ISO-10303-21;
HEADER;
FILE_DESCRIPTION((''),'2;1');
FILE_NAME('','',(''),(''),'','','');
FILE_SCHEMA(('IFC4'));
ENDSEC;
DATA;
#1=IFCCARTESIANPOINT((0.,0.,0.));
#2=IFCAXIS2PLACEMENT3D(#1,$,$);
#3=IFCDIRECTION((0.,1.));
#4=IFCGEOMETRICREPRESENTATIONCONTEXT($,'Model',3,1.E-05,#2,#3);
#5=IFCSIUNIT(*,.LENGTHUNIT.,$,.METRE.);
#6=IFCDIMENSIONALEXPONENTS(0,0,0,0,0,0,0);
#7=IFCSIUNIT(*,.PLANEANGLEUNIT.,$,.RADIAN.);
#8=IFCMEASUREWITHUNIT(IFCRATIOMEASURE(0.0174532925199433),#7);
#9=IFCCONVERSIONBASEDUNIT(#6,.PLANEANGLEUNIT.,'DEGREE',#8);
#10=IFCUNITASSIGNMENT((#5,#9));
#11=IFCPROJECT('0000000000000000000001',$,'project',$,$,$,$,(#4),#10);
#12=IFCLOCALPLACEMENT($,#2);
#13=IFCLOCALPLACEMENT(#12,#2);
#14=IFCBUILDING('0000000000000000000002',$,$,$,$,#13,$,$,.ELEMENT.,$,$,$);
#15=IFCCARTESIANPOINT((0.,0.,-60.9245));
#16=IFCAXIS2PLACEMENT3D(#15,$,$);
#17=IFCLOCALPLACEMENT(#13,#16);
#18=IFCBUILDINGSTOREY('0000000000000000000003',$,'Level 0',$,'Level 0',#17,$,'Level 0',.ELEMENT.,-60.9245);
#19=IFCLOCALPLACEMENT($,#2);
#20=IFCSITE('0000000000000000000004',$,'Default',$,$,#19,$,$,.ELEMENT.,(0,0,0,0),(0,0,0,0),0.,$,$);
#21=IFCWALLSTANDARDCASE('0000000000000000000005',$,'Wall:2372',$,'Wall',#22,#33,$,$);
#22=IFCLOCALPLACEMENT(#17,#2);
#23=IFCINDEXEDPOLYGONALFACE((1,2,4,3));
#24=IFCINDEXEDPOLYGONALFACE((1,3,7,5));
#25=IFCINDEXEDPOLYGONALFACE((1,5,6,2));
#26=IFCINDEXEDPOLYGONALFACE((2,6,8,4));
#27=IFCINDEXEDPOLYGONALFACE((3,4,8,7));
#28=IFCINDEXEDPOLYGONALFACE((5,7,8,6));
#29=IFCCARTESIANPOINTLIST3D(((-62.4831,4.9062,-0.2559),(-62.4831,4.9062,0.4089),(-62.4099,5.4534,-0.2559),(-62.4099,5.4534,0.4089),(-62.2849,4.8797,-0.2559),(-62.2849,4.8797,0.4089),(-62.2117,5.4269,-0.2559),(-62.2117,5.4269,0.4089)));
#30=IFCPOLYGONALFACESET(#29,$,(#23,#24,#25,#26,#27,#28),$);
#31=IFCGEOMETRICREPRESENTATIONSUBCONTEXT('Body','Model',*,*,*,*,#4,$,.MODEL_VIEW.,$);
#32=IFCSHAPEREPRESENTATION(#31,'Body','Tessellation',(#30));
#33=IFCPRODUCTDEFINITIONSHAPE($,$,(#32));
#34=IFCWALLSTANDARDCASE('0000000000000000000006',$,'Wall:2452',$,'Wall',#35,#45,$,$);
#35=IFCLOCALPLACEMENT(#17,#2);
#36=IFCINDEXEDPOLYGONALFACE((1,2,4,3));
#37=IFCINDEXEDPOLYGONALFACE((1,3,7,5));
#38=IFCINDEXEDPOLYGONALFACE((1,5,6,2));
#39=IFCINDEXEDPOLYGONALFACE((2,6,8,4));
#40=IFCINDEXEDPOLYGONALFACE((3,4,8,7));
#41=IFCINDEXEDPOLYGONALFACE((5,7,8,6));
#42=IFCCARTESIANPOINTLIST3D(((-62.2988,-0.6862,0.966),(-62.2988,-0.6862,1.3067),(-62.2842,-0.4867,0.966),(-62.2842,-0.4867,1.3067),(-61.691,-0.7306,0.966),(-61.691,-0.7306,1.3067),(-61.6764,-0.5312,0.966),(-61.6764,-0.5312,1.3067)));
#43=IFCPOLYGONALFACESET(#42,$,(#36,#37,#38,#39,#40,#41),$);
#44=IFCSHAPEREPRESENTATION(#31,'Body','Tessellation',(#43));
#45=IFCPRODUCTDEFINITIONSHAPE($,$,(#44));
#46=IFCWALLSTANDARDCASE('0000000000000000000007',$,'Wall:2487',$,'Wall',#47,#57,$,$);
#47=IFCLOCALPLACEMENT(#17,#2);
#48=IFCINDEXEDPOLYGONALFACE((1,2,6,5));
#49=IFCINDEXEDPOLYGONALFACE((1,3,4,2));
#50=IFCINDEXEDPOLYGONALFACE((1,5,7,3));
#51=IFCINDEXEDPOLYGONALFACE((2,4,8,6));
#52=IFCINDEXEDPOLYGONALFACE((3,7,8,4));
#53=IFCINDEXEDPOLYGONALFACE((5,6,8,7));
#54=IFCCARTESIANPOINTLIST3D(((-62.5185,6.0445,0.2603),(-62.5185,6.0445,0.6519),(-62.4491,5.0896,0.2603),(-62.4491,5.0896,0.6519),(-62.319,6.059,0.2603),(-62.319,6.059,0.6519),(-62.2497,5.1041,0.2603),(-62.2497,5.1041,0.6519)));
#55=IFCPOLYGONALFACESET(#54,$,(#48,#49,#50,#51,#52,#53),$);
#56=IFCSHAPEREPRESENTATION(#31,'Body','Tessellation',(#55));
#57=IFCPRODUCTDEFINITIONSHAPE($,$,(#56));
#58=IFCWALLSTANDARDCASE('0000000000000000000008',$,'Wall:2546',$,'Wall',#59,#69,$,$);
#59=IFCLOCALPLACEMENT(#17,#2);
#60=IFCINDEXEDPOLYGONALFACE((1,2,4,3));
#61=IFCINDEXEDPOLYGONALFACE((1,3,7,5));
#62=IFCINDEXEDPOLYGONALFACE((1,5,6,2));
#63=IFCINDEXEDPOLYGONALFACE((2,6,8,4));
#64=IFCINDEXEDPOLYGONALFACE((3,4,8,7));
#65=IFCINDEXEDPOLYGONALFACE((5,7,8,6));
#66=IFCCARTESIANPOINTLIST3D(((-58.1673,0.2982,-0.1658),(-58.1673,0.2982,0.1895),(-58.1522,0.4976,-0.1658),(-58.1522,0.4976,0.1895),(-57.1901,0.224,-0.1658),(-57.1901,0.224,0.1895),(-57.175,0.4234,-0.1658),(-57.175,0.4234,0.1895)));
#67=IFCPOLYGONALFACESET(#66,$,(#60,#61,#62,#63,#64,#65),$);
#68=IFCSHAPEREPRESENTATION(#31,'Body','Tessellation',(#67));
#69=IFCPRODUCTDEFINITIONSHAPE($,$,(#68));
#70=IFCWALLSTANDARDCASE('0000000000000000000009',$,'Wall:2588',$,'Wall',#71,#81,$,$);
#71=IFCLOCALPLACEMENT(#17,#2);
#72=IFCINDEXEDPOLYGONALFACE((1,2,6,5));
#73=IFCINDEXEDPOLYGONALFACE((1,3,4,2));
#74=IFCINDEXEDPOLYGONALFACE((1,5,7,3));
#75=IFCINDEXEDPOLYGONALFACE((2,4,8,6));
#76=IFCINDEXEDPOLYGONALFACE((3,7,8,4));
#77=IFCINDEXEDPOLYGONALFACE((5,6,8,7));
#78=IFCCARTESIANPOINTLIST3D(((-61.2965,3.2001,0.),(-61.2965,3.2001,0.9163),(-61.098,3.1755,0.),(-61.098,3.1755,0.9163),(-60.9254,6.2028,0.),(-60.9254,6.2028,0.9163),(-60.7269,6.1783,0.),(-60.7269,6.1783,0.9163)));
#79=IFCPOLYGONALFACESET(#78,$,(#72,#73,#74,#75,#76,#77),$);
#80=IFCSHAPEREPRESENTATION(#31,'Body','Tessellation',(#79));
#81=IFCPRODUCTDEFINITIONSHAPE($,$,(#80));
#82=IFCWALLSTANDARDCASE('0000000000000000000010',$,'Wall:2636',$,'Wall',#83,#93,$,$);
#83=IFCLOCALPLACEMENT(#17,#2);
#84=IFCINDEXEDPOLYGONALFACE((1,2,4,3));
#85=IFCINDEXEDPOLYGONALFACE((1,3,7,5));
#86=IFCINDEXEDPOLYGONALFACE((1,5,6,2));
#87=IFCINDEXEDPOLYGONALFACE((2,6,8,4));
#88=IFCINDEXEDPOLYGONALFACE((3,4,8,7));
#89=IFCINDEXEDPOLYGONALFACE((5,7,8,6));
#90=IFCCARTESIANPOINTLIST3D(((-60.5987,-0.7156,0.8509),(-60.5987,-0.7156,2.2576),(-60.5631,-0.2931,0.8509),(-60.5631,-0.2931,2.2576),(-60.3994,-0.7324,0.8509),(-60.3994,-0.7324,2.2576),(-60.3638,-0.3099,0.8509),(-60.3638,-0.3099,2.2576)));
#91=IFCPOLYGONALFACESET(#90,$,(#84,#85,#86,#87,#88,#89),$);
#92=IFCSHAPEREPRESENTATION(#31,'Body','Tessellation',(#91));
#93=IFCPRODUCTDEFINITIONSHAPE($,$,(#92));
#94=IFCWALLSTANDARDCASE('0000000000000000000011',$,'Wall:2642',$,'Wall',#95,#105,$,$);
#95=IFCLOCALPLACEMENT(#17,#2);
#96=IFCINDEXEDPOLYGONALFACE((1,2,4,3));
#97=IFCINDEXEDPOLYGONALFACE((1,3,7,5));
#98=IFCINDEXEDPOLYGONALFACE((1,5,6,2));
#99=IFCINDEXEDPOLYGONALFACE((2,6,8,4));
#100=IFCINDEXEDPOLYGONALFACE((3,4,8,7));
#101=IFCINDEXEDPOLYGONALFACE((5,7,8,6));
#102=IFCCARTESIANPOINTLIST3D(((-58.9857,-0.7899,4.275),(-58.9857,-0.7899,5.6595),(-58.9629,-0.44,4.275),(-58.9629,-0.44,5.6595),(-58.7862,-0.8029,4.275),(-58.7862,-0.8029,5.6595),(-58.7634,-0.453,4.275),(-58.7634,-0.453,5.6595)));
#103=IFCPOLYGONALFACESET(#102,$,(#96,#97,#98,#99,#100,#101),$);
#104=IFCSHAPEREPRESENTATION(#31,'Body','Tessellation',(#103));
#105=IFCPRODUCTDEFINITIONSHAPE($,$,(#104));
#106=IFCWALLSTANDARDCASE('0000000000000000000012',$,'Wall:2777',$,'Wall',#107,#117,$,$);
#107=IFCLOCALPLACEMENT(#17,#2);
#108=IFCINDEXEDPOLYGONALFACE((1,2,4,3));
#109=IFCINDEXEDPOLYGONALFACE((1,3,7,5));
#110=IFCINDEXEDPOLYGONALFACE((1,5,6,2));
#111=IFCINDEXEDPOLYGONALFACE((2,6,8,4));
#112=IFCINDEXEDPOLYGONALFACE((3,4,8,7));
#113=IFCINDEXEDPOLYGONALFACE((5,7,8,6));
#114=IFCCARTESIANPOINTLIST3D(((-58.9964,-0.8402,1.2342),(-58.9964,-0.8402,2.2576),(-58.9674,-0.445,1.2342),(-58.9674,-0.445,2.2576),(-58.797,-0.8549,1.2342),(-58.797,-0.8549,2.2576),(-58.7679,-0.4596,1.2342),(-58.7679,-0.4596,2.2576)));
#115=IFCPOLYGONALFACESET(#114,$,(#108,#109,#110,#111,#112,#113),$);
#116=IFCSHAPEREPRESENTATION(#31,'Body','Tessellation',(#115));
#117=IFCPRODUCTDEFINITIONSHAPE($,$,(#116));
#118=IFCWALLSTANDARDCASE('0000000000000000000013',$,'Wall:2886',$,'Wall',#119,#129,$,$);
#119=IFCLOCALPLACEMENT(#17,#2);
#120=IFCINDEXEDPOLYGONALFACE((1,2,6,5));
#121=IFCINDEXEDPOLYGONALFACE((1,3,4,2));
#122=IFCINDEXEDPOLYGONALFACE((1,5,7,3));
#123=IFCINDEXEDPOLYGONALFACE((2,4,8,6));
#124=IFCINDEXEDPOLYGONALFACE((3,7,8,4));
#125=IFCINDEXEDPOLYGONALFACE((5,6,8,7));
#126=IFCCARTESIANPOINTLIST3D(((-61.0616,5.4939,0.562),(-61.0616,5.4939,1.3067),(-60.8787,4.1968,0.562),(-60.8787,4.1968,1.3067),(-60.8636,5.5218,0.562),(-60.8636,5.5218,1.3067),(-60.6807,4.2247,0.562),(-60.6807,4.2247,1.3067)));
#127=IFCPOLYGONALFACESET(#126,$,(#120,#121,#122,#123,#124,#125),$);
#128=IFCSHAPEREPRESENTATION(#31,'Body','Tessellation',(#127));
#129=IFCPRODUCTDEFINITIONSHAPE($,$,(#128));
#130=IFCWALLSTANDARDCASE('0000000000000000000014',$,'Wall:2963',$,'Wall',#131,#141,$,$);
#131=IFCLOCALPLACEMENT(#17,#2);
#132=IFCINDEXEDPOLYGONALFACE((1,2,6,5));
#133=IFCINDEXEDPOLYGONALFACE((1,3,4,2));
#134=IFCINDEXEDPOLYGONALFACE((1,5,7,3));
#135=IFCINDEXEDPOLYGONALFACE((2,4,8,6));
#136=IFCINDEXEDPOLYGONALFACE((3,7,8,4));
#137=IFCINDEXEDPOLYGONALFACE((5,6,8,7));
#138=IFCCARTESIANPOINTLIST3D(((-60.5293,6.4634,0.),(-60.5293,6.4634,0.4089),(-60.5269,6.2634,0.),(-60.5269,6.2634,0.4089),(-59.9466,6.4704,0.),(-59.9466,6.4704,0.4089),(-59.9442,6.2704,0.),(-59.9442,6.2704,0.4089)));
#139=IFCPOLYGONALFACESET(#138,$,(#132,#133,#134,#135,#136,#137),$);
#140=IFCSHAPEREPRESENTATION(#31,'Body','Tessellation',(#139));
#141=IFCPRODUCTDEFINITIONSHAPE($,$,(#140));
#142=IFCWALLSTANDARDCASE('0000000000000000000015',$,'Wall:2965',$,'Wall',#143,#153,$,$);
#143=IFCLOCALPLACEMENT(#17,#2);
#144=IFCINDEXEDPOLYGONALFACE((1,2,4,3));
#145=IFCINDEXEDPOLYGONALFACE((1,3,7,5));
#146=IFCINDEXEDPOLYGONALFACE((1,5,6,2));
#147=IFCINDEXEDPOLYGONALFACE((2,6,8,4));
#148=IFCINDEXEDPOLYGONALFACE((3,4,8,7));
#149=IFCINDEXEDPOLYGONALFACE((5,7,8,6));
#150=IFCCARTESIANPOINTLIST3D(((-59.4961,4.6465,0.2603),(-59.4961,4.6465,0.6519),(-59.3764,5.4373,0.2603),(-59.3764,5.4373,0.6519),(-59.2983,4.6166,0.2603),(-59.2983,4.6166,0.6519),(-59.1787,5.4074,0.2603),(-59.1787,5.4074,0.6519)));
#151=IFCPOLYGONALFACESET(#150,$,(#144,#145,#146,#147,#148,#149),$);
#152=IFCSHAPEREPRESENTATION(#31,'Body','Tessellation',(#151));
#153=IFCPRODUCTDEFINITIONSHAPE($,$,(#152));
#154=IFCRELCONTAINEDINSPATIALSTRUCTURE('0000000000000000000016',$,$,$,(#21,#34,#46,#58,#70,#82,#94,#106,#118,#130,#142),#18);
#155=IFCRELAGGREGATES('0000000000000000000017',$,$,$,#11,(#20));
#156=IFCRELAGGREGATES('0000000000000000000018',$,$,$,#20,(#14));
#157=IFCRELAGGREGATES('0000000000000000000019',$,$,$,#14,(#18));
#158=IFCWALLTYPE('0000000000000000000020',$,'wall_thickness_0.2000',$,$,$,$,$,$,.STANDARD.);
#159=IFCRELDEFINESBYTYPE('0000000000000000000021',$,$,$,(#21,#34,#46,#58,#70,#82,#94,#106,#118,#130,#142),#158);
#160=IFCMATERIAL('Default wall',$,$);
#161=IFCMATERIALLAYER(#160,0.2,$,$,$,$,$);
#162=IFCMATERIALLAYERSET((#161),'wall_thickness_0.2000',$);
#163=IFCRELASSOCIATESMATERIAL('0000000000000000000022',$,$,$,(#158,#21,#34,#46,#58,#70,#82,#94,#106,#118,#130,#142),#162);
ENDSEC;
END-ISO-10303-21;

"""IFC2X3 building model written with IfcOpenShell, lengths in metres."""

from ifc_helpers import new_model, entity, si_unit, converted_unit, direction, frame, origin, place, context, subcontext, project, spatial, polyline, outline, extrude, material, layer, layer_set, layer_usage, type_object, element, save


model = new_model("IFC2X3")

# Units and contexts
model_context = context("Model", 3, precision=1e-05, world=origin(), true_north=direction((0.0, 1.0)))
body_context = subcontext(model_context, "Body", "Model", "MODEL_VIEW")
ifc_project = project(units=[si_unit("LENGTHUNIT", "METRE"), converted_unit("PLANEANGLEUNIT", "DEGREE", entity("IfcRatioMeasure", 0.0174532925199433), si_unit("PLANEANGLEUNIT", "RADIAN"), dimensions=[0, 0, 0, 0, 0, 0, 0])], contexts=[model_context])

# Site, building, storey
site_placement = place(None, origin())
site = spatial("IfcSite", under=ifc_project, at=site_placement, Name="Default", CompositionType="ELEMENT", RefLatitude=(0, 0, 0, 0), RefLongitude=(0, 0, 0, 0), RefElevation=0.0)
placement_1 = place(None, origin())
building_placement = place(placement_1, origin())
building = spatial("IfcBuilding", under=site, at=building_placement, CompositionType="ELEMENT")
storey_placement = place(building_placement, frame((0.0, 0.0, -60.9245)))
storey = spatial("IfcBuildingStorey", under=building, at=storey_placement, Name="Level 0", ObjectType="Level 0", LongName="Level 0", CompositionType="ELEMENT", Elevation=-60.9245)

# Walls
ifc_material = material(Name="Default wall")
ifc_layer = layer(ifc_material, 0.2)
ifc_layer_set = layer_set([ifc_layer], Name="wall_thickness_0.2000")
ifc_layer_usage = layer_usage(ifc_layer_set, "AXIS2", "POSITIVE", -0.1)
wall_type = type_object("IfcWallType", Name="wall_thickness_0.2000", PredefinedType="STANDARD", material=ifc_layer_set)
placement_2 = place(building_placement, frame((0.0, 0.0, -61.1804)))
wall_1_placement = place(placement_2, frame((-62.3108, 5.4402, 0.0), z_axis=(0.0, 0.0, 1.0), x_axis=(-0.13268, -0.991159, 0.0)))
element("IfcWallStandardCase", 1, at=wall_1_placement, inside=storey, type_object=wall_type, material=ifc_layer_usage, Name="Wall:2372", ObjectType="Wall", context=body_context, shape_type="SweptSolid", body=[
    extrude(outline(polyline([(0.5521, -0.1), (0.5521, 0.1), (0.0, 0.1), (0.0, -0.1), (0.5521, -0.1)])), origin(), (0.0, 0.0, 1.0), 0.6648),
])
placement_3 = place(building_placement, frame((0.0, 0.0, -59.9585)))
wall_2_placement = place(placement_3, frame((-61.6837, -0.6309, 0.0), z_axis=(0.0, 0.0, 1.0), x_axis=(-0.997336, 0.072949, 0.0)))
element("IfcWallStandardCase", 2, at=wall_2_placement, inside=storey, type_object=wall_type, material=ifc_layer_usage, Name="Wall:2452", ObjectType="Wall", context=body_context, shape_type="SweptSolid", body=[
    extrude(outline(polyline([(0.6094, -0.1), (0.6094, 0.1), (0.0, 0.1), (0.0, -0.1), (0.6094, -0.1)])), origin(), (0.0, 0.0, 1.0), 0.3407),
])
placement_4 = place(building_placement, frame((0.0, 0.0, -60.6642)))
wall_3_placement = place(placement_4, frame((-62.4188, 6.0518, 0.0), z_axis=(0.0, 0.0, 1.0), x_axis=(0.072467, -0.997371, 0.0)))
element("IfcWallStandardCase", 3, at=wall_3_placement, inside=storey, type_object=wall_type, material=ifc_layer_usage, Name="Wall:2487", ObjectType="Wall", context=body_context, shape_type="SweptSolid", body=[
    extrude(outline(polyline([(0.9574, -0.1), (0.9574, 0.1), (0.0, 0.1), (0.0, -0.1), (0.9574, -0.1)])), origin(), (0.0, 0.0, 1.0), 0.3916),
])
placement_5 = place(building_placement, frame((0.0, 0.0, -61.0903)))
wall_4_placement = place(placement_5, frame((-58.1598, 0.3979, 0.0), z_axis=(0.0, 0.0, 1.0), x_axis=(0.997126, -0.075762, 0.0)))
element("IfcWallStandardCase", 4, at=wall_4_placement, inside=storey, type_object=wall_type, material=ifc_layer_usage, Name="Wall:2546", ObjectType="Wall", context=body_context, shape_type="SweptSolid", body=[
    extrude(outline(polyline([(0.98, -0.1), (0.98, 0.1), (0.0, 0.1), (0.0, -0.1), (0.98, -0.1)])), origin(), (0.0, 0.0, 1.0), 0.3553),
])
wall_5_placement = place(storey_placement, frame((-61.1973, 3.1878, 0.0), z_axis=(0.0, 0.0, 1.0), x_axis=(0.122664, 0.992448, 0.0)))
element("IfcWallStandardCase", 5, at=wall_5_placement, inside=storey, type_object=wall_type, material=ifc_layer_usage, Name="Wall:2588", ObjectType="Wall", context=body_context, shape_type="SweptSolid", body=[
    extrude(outline(polyline([(3.0256, -0.1), (3.0256, 0.1), (0.0, 0.1), (0.0, -0.1), (3.0256, -0.1)])), origin(), (0.0, 0.0, 1.0), 0.9163),
])
placement_6 = place(building_placement, frame((0.0, 0.0, -60.0736)))
wall_6_placement = place(placement_6, frame((-60.4635, -0.3015, 0.0), z_axis=(0.0, 0.0, 1.0), x_axis=(-0.083884, -0.996475, 0.0)))
element("IfcWallStandardCase", 6, at=wall_6_placement, inside=storey, type_object=wall_type, material=ifc_layer_usage, Name="Wall:2636", ObjectType="Wall", context=body_context, shape_type="SweptSolid", body=[
    extrude(outline(polyline([(0.424, -0.1), (0.424, 0.1), (0.0, 0.1), (0.0, -0.1), (0.424, -0.1)])), origin(), (0.0, 0.0, 1.0), 1.4068),
])
placement_7 = place(building_placement, frame((0.0, 0.0, -56.6495)))
wall_7_placement = place(placement_7, frame((-58.8632, -0.4465, 0.0), z_axis=(0.0, 0.0, 1.0), x_axis=(-0.064996, -0.997886, 0.0)))
element("IfcWallStandardCase", 7, at=wall_7_placement, inside=storey, type_object=wall_type, material=ifc_layer_usage, Name="Wall:2642", ObjectType="Wall", context=body_context, shape_type="SweptSolid", body=[
    extrude(outline(polyline([(0.3507, -0.1), (0.3507, 0.1), (0.0, 0.1), (0.0, -0.1), (0.3507, -0.1)])), origin(), (0.0, 0.0, 1.0), 1.3845),
])
placement_8 = place(building_placement, frame((0.0, 0.0, -59.6903)))
wall_8_placement = place(placement_8, frame((-58.8676, -0.4523, 0.0), z_axis=(0.0, 0.0, 1.0), x_axis=(-0.073278, -0.997312, 0.0)))
element("IfcWallStandardCase", 8, at=wall_8_placement, inside=storey, type_object=wall_type, material=ifc_layer_usage, Name="Wall:2777", ObjectType="Wall", context=body_context, shape_type="SweptSolid", body=[
    extrude(outline(polyline([(0.3963, -0.1), (0.3963, 0.1), (0.0, 0.1), (0.0, -0.1), (0.3963, -0.1)])), origin(), (0.0, 0.0, 1.0), 1.0234),
])
placement_9 = place(building_placement, frame((0.0, 0.0, -60.3625)))
wall_9_placement = place(placement_9, frame((-60.9626, 5.5079, 0.0), z_axis=(0.0, 0.0, 1.0), x_axis=(0.139595, -0.990209, 0.0)))
element("IfcWallStandardCase", 9, at=wall_9_placement, inside=storey, type_object=wall_type, material=ifc_layer_usage, Name="Wall:2886", ObjectType="Wall", context=body_context, shape_type="SweptSolid", body=[
    extrude(outline(polyline([(1.31, -0.1), (1.31, 0.1), (0.0, 0.1), (0.0, -0.1), (1.31, -0.1)])), origin(), (0.0, 0.0, 1.0), 0.7448),
])
wall_10_placement = place(storey_placement, frame((-60.5281, 6.3634, 0.0), z_axis=(0.0, 0.0, 1.0), x_axis=(0.999928, 0.011975, 0.0)))
element("IfcWallStandardCase", 10, at=wall_10_placement, inside=storey, type_object=wall_type, material=ifc_layer_usage, Name="Wall:2963", ObjectType="Wall", context=body_context, shape_type="SweptSolid", body=[
    extrude(outline(polyline([(0.5827, -0.1), (0.5827, 0.1), (0.0, 0.1), (0.0, -0.1), (0.5827, -0.1)])), origin(), (0.0, 0.0, 1.0), 0.4089),
])
placement_10 = place(building_placement, frame((0.0, 0.0, -60.6642)))
wall_11_placement = place(placement_10, frame((-59.3972, 4.6316, 0.0), z_axis=(0.0, 0.0, 1.0), x_axis=(0.149564, 0.988752, 0.0)))
element("IfcWallStandardCase", 11, at=wall_11_placement, inside=storey, type_object=wall_type, material=ifc_layer_usage, Name="Wall:2965", ObjectType="Wall", context=body_context, shape_type="SweptSolid", body=[
    extrude(outline(polyline([(0.7998, -0.1), (0.7998, 0.1), (0.0, 0.1), (0.0, -0.1), (0.7998, -0.1)])), origin(), (0.0, 0.0, 1.0), 0.3916),
])

save(model, "model.ifc")
